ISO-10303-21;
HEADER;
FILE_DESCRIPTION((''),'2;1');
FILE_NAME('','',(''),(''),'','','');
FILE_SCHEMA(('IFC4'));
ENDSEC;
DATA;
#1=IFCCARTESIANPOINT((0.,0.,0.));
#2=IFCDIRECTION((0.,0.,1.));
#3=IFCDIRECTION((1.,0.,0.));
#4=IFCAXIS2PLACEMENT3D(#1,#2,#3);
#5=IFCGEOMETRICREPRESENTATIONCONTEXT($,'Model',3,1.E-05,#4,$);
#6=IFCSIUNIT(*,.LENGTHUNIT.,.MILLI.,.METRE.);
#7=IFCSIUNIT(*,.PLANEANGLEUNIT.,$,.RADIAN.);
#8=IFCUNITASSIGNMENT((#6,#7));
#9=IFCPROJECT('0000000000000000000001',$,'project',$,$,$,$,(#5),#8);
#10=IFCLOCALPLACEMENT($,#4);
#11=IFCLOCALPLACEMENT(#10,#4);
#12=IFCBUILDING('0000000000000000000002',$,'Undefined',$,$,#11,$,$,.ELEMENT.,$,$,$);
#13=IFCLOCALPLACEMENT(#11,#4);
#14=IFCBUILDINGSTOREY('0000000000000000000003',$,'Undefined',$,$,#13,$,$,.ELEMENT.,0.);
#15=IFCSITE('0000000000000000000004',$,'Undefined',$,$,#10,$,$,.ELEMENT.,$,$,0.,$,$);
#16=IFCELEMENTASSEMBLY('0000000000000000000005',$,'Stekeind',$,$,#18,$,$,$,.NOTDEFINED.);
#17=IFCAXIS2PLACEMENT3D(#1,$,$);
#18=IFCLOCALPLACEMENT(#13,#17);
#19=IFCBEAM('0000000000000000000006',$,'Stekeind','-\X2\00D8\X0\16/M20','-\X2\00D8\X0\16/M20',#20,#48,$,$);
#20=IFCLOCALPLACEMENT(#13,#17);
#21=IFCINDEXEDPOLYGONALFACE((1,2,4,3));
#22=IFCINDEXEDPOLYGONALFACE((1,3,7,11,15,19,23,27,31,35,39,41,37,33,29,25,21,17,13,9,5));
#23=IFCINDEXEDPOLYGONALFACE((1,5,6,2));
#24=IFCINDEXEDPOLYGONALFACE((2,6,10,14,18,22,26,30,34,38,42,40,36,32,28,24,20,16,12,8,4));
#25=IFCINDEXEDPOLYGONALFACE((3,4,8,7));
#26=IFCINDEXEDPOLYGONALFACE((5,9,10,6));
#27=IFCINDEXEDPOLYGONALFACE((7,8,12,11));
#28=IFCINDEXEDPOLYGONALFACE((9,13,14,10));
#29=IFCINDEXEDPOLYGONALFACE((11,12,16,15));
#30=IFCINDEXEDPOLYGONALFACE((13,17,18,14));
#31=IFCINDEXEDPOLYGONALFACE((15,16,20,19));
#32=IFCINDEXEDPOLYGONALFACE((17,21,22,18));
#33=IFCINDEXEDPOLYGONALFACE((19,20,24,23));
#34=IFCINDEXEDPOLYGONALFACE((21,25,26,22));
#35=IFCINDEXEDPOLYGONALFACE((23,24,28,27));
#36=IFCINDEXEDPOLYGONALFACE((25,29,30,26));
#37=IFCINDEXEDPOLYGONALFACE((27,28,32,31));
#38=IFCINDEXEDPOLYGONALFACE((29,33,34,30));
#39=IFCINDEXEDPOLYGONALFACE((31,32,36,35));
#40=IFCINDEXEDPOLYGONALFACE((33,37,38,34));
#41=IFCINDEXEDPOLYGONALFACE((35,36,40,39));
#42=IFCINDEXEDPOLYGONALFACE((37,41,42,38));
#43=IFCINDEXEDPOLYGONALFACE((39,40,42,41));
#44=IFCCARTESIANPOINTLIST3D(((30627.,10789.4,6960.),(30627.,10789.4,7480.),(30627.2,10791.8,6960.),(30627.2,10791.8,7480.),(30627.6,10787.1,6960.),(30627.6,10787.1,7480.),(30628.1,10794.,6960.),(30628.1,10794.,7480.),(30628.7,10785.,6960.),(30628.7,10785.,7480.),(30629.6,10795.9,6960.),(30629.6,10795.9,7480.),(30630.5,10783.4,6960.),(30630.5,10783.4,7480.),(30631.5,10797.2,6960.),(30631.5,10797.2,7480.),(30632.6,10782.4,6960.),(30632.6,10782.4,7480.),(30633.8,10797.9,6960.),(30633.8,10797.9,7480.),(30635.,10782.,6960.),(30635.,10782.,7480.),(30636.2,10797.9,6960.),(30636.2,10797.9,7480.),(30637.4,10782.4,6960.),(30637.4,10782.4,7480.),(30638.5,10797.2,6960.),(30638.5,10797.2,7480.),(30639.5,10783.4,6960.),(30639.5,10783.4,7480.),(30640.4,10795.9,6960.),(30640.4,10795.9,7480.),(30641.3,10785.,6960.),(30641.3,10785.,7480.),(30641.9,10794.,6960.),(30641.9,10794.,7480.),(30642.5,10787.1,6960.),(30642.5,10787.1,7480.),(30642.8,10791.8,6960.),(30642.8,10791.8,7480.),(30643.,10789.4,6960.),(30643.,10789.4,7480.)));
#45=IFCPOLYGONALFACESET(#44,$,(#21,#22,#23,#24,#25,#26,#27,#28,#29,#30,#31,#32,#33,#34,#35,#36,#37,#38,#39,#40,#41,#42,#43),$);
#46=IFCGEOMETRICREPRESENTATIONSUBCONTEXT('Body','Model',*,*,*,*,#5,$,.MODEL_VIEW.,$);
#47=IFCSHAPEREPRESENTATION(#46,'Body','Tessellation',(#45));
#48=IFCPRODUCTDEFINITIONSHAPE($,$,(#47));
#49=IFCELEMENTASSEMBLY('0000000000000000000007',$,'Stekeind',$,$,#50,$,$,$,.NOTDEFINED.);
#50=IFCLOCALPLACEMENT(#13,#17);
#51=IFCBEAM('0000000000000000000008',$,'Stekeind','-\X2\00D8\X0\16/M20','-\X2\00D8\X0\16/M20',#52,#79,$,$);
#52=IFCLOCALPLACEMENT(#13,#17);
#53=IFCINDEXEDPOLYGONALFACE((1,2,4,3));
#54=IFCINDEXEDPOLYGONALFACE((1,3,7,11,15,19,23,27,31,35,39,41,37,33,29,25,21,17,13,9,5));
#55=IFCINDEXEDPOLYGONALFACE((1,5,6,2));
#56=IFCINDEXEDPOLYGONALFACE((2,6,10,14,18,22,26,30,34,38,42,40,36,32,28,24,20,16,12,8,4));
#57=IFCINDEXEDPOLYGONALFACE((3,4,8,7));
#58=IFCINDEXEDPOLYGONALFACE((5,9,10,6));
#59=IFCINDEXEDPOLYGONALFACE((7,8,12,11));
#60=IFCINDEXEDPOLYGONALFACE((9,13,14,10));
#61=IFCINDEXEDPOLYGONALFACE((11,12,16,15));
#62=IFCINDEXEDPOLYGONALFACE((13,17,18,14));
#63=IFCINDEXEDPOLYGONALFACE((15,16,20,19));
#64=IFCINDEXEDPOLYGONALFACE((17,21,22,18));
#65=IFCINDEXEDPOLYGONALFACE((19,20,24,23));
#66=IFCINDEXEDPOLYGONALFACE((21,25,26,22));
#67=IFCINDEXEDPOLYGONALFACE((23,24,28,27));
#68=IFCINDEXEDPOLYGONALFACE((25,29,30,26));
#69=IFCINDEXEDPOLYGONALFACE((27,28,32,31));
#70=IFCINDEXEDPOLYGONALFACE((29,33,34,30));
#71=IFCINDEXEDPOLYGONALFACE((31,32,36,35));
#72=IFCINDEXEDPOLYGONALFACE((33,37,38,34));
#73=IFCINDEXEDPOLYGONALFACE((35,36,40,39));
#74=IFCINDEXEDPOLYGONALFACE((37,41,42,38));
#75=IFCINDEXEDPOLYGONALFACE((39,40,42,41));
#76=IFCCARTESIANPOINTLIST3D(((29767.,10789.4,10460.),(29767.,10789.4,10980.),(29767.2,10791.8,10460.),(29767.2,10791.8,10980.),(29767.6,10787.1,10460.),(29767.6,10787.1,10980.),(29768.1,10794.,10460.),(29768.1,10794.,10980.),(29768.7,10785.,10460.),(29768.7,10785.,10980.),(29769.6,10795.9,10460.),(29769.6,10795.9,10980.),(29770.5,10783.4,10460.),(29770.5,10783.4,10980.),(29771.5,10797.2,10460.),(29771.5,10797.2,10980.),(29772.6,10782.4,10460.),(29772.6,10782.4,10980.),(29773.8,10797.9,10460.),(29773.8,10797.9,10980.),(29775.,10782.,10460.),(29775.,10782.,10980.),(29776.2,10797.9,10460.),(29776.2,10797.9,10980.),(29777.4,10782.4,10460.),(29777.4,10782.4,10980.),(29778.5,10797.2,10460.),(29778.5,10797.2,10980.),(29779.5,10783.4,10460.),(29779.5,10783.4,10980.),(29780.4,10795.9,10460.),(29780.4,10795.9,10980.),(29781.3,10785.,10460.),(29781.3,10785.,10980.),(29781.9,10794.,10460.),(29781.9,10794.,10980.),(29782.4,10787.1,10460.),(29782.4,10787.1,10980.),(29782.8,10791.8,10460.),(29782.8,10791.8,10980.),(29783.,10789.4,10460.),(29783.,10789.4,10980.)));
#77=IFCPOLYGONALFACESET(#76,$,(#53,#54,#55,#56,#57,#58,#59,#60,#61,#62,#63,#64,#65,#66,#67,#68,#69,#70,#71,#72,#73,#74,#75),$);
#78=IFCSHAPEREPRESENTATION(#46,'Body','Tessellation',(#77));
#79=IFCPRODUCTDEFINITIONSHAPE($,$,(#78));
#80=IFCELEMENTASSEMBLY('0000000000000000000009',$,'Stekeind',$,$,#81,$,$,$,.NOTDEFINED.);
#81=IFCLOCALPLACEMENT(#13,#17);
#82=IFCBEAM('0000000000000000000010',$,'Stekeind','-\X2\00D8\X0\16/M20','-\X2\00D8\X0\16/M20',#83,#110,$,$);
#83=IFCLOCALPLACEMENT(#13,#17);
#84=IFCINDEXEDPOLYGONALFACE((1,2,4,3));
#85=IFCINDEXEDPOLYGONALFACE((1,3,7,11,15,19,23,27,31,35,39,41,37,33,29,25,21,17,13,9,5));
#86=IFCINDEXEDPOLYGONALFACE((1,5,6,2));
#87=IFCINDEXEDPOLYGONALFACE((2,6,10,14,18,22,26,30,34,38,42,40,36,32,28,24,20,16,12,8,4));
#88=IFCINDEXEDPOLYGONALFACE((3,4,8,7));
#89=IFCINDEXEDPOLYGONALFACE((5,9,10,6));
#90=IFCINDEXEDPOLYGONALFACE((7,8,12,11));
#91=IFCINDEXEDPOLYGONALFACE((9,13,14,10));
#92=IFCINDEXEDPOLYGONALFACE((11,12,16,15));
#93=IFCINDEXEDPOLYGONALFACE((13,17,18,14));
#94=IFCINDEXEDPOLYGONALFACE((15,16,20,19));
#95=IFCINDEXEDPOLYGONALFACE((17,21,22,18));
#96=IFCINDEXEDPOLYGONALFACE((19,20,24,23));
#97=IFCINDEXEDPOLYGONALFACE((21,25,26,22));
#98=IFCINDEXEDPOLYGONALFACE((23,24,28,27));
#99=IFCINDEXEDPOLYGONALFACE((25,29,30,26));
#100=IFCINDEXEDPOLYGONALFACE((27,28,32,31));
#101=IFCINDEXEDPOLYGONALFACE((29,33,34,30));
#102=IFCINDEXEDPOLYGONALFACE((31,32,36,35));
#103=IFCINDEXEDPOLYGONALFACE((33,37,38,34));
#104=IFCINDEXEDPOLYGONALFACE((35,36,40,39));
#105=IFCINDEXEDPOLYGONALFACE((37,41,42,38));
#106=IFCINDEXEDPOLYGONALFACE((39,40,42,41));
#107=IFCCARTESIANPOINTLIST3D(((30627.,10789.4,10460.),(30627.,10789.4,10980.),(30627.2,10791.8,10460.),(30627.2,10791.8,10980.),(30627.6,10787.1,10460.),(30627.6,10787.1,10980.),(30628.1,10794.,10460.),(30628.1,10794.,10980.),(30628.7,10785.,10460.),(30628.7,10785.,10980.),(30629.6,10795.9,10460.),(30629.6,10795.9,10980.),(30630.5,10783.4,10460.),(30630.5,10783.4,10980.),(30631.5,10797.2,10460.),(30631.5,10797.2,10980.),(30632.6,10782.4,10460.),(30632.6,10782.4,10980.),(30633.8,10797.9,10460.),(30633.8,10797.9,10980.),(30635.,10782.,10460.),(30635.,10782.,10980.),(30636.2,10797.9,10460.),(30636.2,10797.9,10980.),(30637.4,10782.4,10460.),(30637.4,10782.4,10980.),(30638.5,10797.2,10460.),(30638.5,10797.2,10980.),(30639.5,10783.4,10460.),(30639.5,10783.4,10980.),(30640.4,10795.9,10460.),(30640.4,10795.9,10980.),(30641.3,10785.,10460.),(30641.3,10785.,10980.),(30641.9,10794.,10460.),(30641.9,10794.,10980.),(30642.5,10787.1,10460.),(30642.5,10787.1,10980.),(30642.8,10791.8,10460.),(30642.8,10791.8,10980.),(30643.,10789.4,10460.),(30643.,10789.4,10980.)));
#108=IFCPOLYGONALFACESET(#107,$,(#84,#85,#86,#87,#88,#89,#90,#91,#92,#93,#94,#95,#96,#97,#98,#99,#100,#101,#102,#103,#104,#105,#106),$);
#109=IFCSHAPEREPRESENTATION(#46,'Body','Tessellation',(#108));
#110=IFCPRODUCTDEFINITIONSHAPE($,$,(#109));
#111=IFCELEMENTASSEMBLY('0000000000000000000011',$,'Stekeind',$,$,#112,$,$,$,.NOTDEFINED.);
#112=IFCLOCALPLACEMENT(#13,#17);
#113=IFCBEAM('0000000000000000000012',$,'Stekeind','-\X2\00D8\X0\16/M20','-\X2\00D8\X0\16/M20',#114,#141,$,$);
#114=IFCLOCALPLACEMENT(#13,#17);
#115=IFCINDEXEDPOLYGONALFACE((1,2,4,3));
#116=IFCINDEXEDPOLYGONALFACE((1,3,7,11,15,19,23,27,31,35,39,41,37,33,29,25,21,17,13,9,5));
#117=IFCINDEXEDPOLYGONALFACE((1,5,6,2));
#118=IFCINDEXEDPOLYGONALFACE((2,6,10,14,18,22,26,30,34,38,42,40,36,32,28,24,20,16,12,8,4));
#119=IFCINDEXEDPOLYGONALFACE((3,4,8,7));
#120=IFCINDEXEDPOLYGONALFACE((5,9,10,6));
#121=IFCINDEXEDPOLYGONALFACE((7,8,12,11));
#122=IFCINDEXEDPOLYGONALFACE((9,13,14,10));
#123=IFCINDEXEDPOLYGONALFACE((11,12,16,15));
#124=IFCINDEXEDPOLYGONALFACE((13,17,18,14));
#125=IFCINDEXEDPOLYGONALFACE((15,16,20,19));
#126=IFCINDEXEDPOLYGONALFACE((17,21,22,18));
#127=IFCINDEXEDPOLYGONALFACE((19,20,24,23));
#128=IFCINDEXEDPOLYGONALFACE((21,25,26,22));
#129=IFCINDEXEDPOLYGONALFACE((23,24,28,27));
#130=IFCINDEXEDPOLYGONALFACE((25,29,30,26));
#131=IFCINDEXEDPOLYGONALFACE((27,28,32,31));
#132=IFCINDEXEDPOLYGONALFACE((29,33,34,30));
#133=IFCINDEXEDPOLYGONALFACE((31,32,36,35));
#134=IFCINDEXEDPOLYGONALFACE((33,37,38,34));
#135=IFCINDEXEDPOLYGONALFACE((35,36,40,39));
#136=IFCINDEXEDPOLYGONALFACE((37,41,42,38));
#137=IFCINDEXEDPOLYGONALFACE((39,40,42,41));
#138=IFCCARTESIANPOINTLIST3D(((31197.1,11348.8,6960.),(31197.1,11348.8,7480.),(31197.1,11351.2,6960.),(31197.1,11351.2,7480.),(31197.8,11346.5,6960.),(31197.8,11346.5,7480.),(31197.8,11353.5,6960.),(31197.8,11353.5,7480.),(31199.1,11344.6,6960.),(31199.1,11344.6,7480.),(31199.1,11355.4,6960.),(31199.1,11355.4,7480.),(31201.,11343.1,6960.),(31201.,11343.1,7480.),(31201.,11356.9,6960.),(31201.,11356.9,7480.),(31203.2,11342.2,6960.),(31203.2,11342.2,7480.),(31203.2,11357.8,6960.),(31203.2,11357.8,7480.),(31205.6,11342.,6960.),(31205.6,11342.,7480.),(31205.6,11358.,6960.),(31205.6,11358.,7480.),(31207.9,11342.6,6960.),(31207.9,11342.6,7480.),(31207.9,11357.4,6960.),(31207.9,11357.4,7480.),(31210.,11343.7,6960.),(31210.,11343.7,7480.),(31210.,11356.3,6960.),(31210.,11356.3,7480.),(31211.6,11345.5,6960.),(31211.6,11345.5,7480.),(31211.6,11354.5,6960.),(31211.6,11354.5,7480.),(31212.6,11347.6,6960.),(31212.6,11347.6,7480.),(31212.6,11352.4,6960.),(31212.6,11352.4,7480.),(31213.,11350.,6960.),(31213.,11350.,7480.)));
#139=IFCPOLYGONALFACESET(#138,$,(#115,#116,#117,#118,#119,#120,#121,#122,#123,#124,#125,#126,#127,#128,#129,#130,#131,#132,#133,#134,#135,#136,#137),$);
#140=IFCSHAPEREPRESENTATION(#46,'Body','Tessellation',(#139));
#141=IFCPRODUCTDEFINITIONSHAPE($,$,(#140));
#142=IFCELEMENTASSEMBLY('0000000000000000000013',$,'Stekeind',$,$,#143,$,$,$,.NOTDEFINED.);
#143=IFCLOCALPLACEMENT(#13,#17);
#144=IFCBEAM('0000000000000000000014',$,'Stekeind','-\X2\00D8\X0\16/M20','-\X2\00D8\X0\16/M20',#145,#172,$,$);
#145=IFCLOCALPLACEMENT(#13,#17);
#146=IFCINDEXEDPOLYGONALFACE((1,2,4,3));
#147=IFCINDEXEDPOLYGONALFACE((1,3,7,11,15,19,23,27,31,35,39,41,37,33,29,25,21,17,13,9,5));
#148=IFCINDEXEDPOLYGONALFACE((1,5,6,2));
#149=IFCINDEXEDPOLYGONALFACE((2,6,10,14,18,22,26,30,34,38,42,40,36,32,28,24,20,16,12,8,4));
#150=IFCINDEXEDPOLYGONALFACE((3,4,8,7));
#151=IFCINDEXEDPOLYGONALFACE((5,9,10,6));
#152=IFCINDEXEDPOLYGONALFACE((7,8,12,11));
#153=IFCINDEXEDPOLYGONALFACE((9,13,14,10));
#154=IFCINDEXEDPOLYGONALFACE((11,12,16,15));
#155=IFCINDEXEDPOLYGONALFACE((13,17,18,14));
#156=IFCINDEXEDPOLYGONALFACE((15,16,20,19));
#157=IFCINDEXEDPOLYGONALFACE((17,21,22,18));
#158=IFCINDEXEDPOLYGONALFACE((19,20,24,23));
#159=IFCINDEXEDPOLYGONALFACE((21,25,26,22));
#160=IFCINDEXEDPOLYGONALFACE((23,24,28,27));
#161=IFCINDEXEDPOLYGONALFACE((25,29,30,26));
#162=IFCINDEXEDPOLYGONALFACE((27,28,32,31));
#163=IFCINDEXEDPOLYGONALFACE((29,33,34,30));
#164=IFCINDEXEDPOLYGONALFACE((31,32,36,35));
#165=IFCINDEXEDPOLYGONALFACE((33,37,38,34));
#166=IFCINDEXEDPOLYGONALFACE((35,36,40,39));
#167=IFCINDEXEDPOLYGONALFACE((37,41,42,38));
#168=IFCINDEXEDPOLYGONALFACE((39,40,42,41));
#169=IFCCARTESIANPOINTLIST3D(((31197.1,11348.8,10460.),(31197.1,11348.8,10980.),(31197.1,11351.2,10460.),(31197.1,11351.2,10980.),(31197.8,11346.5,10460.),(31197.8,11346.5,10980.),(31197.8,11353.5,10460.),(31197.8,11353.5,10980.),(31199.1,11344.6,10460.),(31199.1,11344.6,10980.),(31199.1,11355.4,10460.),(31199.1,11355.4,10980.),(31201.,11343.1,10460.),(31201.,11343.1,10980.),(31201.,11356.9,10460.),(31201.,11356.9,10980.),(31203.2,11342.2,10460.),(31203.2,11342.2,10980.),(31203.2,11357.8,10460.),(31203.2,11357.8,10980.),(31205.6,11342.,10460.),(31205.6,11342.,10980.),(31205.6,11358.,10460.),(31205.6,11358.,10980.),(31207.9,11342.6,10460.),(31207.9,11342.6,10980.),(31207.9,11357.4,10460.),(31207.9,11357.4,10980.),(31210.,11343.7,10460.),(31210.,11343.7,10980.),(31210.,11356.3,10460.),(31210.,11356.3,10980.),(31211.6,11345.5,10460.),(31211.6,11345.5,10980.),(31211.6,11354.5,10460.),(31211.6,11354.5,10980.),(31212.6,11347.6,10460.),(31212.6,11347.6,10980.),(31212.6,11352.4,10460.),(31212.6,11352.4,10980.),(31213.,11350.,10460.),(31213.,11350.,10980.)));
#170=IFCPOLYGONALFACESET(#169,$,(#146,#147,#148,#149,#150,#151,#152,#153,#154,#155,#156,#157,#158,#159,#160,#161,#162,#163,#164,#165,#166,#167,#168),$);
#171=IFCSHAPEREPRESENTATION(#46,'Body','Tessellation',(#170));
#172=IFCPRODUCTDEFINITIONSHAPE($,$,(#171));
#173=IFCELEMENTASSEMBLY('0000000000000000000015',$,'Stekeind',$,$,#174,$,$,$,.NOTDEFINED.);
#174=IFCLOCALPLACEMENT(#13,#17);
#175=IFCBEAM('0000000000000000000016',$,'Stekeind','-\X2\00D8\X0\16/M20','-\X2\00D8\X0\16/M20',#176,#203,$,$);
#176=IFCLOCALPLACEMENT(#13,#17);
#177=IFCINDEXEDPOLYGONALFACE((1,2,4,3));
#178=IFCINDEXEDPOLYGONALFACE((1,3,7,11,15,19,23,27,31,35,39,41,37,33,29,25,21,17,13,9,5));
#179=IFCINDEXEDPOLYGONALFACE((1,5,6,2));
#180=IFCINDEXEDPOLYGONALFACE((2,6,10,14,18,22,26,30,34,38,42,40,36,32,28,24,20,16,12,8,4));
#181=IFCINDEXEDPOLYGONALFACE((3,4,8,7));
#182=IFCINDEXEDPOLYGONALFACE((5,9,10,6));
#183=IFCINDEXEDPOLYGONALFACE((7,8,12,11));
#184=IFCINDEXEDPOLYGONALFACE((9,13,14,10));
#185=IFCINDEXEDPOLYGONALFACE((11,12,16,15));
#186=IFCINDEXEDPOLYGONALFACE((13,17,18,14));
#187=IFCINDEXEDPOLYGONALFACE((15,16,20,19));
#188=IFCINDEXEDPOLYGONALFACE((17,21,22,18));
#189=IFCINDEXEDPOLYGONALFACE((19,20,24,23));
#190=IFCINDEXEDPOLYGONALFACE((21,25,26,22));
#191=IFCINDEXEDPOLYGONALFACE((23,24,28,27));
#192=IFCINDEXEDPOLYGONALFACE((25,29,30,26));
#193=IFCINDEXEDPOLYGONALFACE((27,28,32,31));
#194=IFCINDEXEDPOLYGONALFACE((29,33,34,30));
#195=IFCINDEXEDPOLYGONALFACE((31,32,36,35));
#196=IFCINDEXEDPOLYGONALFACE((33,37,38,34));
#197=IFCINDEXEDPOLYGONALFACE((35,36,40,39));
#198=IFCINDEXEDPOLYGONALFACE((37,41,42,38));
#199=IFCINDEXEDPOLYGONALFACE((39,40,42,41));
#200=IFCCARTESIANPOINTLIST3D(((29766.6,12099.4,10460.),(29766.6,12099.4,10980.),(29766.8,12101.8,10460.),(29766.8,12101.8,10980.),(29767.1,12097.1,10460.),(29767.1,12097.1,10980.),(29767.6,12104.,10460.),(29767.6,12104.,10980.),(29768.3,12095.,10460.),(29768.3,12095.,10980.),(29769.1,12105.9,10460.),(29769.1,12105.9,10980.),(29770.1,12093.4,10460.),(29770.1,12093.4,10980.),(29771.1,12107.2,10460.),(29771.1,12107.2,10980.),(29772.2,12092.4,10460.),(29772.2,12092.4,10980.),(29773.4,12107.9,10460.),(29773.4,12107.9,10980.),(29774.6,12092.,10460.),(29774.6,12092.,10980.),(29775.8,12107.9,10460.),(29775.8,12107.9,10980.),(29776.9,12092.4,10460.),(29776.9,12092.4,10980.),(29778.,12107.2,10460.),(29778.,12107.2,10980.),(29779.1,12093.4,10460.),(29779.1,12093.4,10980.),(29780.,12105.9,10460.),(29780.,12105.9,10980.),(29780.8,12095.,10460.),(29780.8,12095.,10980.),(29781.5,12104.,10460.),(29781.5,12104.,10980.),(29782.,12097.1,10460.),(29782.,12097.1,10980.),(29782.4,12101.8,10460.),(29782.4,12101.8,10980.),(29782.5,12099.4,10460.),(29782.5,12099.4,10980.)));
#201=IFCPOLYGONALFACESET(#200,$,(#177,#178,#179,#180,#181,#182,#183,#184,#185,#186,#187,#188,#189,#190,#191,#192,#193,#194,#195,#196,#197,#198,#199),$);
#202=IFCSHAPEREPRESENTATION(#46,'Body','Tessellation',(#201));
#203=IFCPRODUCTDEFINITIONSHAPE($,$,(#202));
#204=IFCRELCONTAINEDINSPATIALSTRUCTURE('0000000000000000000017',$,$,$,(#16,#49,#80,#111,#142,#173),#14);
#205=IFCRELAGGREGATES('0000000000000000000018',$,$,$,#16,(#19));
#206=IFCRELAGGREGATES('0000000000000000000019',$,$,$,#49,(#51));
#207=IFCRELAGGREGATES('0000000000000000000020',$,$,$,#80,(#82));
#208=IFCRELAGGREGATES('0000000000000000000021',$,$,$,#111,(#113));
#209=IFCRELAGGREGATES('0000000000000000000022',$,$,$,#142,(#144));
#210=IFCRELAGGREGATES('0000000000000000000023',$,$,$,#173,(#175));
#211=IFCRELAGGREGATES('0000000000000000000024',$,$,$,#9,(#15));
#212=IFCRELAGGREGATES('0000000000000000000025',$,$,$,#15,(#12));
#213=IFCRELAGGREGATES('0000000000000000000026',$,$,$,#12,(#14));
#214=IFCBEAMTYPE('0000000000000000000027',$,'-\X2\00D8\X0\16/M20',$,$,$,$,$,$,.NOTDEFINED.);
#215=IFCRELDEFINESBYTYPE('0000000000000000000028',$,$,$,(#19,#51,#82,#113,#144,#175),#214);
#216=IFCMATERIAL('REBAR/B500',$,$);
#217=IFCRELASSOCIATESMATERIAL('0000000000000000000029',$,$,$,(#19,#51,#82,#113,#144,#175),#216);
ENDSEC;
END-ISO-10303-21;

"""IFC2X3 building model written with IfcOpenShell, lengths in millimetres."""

from ifc_helpers import new_model, si_unit, frame, origin_with_axes, origin_2d_with_axis, place, context, subcontext, project, spatial, circle, extrude, material, type_object, element, aggregate, save


model = new_model("IFC2X3")

# Units and contexts
model_context = context("Model", 3, precision=1e-05, world=origin_with_axes())
body_context = subcontext(model_context, "Body", "Model", "MODEL_VIEW")
ifc_project = project(units=[si_unit("LENGTHUNIT", "METRE", prefix="MILLI"), si_unit("PLANEANGLEUNIT", "RADIAN")], contexts=[model_context])

# Site, building, storey
site_placement = place(None, origin_with_axes())
site = spatial("IfcSite", under=ifc_project, at=site_placement, Name="Undefined", CompositionType="ELEMENT", RefElevation=0.0)
building_placement = place(site_placement, origin_with_axes())
building = spatial("IfcBuilding", under=site, at=building_placement, Name="Undefined", CompositionType="ELEMENT")
storey_placement = place(building_placement, origin_with_axes())
storey = spatial("IfcBuildingStorey", under=building, at=storey_placement, Name="Undefined", CompositionType="ELEMENT", Elevation=0.0)

# Element assemblies, beams
ifc_material_1 = material(Name="REBAR/B500")
beam_type_1 = type_object("IfcBeamType", Name="-Ø16/M20", PredefinedType="NOTDEFINED")
assembly_1_placement = place(storey_placement, origin_with_axes())
assembly_1 = element("IfcElementAssembly", 1, at=assembly_1_placement, inside=storey, Name="Stekeind", PredefinedType="NOTDEFINED")
beam_1_placement = place(assembly_1_placement, frame((30635.0, 10790.0, 7480.0), z_axis=(1.0, 0.0, 0.0), x_axis=(0.0, 0.0, -1.0)))
beam_1 = element("IfcBeam", 2, at=beam_1_placement, type_object=beam_type_1, material=ifc_material_1, Name="Stekeind", Description="-Ø16/M20", ObjectType="-Ø16/M20", context=body_context, shape_type="SweptSolid", body=[
    extrude(circle(Radius=8.0, at=origin_2d_with_axis()), frame((520.0, 0.0, 0.0), z_axis=(-1.0, 0.0, 0.0), x_axis=(0.0, -1.0, 0.0)), (0.0, 0.0, 1.0), 520.0),
])
aggregate(assembly_1, [beam_1])
assembly_2_placement = place(storey_placement, origin_with_axes())
assembly_2 = element("IfcElementAssembly", 3, at=assembly_2_placement, inside=storey, Name="Stekeind", PredefinedType="NOTDEFINED")
beam_2_placement = place(assembly_2_placement, frame((29775.0, 10790.0, 10980.0), z_axis=(1.0, 0.0, 0.0), x_axis=(0.0, 0.0, -1.0)))
beam_2 = element("IfcBeam", 4, at=beam_2_placement, type_object=beam_type_1, material=ifc_material_1, Name="Stekeind", Description="-Ø16/M20", ObjectType="-Ø16/M20", context=body_context, shape_type="SweptSolid", body=[
    extrude(circle(Radius=8.0, at=origin_2d_with_axis()), frame((520.0, 0.0, 0.0), z_axis=(-1.0, 0.0, 0.0), x_axis=(0.0, -1.0, 0.0)), (0.0, 0.0, 1.0), 520.0),
])
aggregate(assembly_2, [beam_2])
assembly_3_placement = place(storey_placement, origin_with_axes())
assembly_3 = element("IfcElementAssembly", 5, at=assembly_3_placement, inside=storey, Name="Stekeind", PredefinedType="NOTDEFINED")
beam_3_placement = place(assembly_3_placement, frame((30635.0, 10790.0, 10980.0), z_axis=(1.0, 0.0, 0.0), x_axis=(0.0, 0.0, -1.0)))
beam_3 = element("IfcBeam", 6, at=beam_3_placement, type_object=beam_type_1, material=ifc_material_1, Name="Stekeind", Description="-Ø16/M20", ObjectType="-Ø16/M20", context=body_context, shape_type="SweptSolid", body=[
    extrude(circle(Radius=8.0, at=origin_2d_with_axis()), frame((520.0, 0.0, 0.0), z_axis=(-1.0, 0.0, 0.0), x_axis=(0.0, -1.0, 0.0)), (0.0, 0.0, 1.0), 520.0),
])
aggregate(assembly_3, [beam_3])
assembly_4_placement = place(storey_placement, origin_with_axes())
assembly_4 = element("IfcElementAssembly", 7, at=assembly_4_placement, inside=storey, Name="Stekeind", PredefinedType="NOTDEFINED")
beam_4_placement = place(assembly_4_placement, frame((31205.0, 11350.0, 7480.0), z_axis=(0.0, 1.0, 0.0), x_axis=(0.0, 0.0, -1.0)))
beam_4 = element("IfcBeam", 8, at=beam_4_placement, type_object=beam_type_1, material=ifc_material_1, Name="Stekeind", Description="-Ø16/M20", ObjectType="-Ø16/M20", context=body_context, shape_type="SweptSolid", body=[
    extrude(circle(Radius=8.0, at=origin_2d_with_axis()), frame((520.0, 0.0, 0.0), z_axis=(-1.0, 0.0, 0.0), x_axis=(0.0, -1.0, 0.0)), (0.0, 0.0, 1.0), 520.0),
])
aggregate(assembly_4, [beam_4])
assembly_5_placement = place(storey_placement, origin_with_axes())
assembly_5 = element("IfcElementAssembly", 9, at=assembly_5_placement, inside=storey, Name="Stekeind", PredefinedType="NOTDEFINED")
beam_5_placement = place(assembly_5_placement, frame((31205.0, 11350.0, 10980.0), z_axis=(0.0, 1.0, 0.0), x_axis=(0.0, 0.0, -1.0)))
beam_5 = element("IfcBeam", 10, at=beam_5_placement, type_object=beam_type_1, material=ifc_material_1, Name="Stekeind", Description="-Ø16/M20", ObjectType="-Ø16/M20", context=body_context, shape_type="SweptSolid", body=[
    extrude(circle(Radius=8.0, at=origin_2d_with_axis()), frame((520.0, 0.0, 0.0), z_axis=(-1.0, 0.0, 0.0), x_axis=(0.0, -1.0, 0.0)), (0.0, 0.0, 1.0), 520.0),
])
aggregate(assembly_5, [beam_5])
assembly_6_placement = place(storey_placement, origin_with_axes())
assembly_6 = element("IfcElementAssembly", 11, at=assembly_6_placement, inside=storey, Name="Stekeind", PredefinedType="NOTDEFINED")
beam_6_placement = place(assembly_6_placement, frame((29774.6, 12100.0, 10980.0), z_axis=(1.0, 0.0, 0.0), x_axis=(0.0, 0.0, -1.0)))
beam_6 = element("IfcBeam", 12, at=beam_6_placement, type_object=beam_type_1, material=ifc_material_1, Name="Stekeind", Description="-Ø16/M20", ObjectType="-Ø16/M20", context=body_context, shape_type="SweptSolid", body=[
    extrude(circle(Radius=8.0, at=origin_2d_with_axis()), frame((520.0, 0.0, 0.0), z_axis=(-1.0, 0.0, 0.0), x_axis=(0.0, -1.0, 0.0)), (0.0, 0.0, 1.0), 520.0),
])
aggregate(assembly_6, [beam_6])

save(model, "model.ifc")
